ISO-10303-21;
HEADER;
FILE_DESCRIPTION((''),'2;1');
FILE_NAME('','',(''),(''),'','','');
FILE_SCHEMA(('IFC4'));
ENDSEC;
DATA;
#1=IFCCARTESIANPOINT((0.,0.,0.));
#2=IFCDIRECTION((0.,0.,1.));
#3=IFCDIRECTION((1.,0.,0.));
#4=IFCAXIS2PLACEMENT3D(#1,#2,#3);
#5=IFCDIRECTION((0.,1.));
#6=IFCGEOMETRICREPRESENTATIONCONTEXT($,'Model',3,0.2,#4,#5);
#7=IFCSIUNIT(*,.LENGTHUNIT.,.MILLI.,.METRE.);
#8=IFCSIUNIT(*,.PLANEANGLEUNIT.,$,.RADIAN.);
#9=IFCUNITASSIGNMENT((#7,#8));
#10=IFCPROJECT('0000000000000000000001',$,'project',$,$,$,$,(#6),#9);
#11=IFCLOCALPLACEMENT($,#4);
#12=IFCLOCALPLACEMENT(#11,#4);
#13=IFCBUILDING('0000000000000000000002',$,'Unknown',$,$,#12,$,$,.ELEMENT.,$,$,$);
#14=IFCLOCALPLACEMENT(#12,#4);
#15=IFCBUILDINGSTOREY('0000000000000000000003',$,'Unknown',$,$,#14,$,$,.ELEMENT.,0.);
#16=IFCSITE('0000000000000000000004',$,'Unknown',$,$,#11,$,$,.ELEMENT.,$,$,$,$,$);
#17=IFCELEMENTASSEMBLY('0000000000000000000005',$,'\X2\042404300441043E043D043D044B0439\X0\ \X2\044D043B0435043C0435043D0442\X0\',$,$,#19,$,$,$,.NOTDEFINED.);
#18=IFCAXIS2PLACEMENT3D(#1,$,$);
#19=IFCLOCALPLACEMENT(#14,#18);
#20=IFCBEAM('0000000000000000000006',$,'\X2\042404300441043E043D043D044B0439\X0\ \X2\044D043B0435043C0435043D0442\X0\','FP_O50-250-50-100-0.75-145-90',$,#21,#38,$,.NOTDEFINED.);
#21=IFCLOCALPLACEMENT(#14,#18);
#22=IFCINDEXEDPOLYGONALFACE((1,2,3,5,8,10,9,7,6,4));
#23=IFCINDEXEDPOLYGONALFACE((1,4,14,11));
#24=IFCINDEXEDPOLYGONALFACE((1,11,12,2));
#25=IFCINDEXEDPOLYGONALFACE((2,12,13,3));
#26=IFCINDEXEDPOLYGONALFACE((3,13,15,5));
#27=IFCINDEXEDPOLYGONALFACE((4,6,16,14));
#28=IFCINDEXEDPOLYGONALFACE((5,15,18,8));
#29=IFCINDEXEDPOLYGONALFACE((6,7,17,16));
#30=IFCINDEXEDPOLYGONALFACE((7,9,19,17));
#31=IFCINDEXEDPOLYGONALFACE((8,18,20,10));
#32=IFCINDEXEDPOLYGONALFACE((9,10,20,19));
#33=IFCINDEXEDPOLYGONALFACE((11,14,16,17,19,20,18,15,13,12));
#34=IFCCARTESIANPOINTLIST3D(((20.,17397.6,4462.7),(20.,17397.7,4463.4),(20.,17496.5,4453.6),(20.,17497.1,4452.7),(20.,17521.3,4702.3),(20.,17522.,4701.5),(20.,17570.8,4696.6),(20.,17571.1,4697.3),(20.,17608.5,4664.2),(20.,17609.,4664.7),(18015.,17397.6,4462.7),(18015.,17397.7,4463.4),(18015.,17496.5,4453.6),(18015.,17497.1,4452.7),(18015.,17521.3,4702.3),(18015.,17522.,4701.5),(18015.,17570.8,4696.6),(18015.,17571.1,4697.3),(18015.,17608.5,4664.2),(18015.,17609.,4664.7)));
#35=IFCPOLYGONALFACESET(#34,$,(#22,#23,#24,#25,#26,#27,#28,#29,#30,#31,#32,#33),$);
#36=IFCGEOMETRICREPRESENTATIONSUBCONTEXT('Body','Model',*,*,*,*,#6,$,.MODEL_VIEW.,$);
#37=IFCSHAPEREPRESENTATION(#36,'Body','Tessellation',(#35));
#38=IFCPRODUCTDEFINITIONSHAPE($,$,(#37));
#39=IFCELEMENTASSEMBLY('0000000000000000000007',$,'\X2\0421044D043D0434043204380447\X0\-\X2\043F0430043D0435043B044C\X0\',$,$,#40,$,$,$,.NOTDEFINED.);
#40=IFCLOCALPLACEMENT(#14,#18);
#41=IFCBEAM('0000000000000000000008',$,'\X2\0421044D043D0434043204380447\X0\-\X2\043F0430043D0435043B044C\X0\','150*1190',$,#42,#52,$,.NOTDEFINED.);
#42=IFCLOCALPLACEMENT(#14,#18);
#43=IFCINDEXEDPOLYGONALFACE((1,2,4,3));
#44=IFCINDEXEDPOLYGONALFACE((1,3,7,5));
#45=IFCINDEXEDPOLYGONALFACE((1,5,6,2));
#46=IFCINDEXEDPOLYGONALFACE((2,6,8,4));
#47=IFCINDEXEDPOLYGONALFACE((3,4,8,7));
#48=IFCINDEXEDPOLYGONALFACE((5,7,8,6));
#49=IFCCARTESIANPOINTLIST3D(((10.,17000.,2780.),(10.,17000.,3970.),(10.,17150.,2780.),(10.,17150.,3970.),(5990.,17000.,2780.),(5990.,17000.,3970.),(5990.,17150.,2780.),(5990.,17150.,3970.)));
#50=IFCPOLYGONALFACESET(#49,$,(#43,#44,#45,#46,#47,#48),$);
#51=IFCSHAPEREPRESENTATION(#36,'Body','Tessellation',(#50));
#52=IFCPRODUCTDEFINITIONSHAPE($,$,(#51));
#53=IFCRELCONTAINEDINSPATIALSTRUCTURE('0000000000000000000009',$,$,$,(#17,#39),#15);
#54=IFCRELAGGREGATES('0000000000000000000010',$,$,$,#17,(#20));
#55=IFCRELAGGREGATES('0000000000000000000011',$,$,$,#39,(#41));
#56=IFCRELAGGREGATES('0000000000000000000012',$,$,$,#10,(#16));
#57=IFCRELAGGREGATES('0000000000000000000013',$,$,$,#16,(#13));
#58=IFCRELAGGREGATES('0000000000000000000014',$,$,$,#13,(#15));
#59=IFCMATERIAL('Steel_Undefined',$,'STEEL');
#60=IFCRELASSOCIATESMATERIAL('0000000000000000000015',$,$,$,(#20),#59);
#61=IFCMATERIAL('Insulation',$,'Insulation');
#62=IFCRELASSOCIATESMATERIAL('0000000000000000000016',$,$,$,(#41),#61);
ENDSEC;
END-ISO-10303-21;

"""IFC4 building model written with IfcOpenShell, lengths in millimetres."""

from ifc_helpers import new_model, si_unit, direction, frame, origin_with_axes, place, context, subcontext, project, spatial, line, indexed_curve, outline, extrude, material, element, aggregate, save


model = new_model("IFC4")

# Units and contexts
model_context = context("Model", 3, precision=0.2, world=origin_with_axes(), true_north=direction((0.0, 1.0)))
body_context = subcontext(model_context, "Body", "Model", "MODEL_VIEW")
ifc_project = project(units=[si_unit("LENGTHUNIT", "METRE", prefix="MILLI"), si_unit("PLANEANGLEUNIT", "RADIAN")], contexts=[model_context])

# Site, building, storey
site_placement = place(None, origin_with_axes())
site = spatial("IfcSite", under=ifc_project, at=site_placement, Name="Unknown", CompositionType="ELEMENT")
building_placement = place(site_placement, origin_with_axes())
building = spatial("IfcBuilding", under=site, at=building_placement, Name="Unknown", CompositionType="ELEMENT")
storey_placement = place(building_placement, origin_with_axes())
storey = spatial("IfcBuildingStorey", under=building, at=storey_placement, Name="Unknown", CompositionType="ELEMENT", Elevation=0.0)

# Element assemblies, beams
assembly_1_placement = place(storey_placement, frame((20.0, 17533.8, 4575.4), z_axis=(0.0, 0.099504, 0.995037), x_axis=(1.0, 0.0, 0.0)))
assembly_1 = element("IfcElementAssembly", 1, at=assembly_1_placement, inside=storey, Name="Фасонный элемент", PredefinedType="NOTDEFINED")
ifc_material_1 = material(Name="Steel_Undefined", Category="STEEL")
beam_1_placement = place(assembly_1_placement, origin_with_axes())
beam_1 = element("IfcBeam", 2, at=beam_1_placement, material=ifc_material_1, Name="Фасонный элемент", Description="FP_O50-250-50-100-0.75-145-90", PredefinedType="NOTDEFINED", context=body_context, shape_type="SolidModel", body=[
    extrude(outline(indexed_curve([(-125.8, -24.2), (-125.8, -124.2), (-125.0, -124.2), (-125.0, -25.0), (125.0, -25.0), (125.0, 25.0), (96.3, 66.0), (95.7, 65.5), (124.2, 24.8), (124.2, -24.2)], segments=[line(1, 2, 3, 4, 5, 6, 7, 8, 9, 10, 1)])), frame((0.0, 0.0, 0.0), z_axis=(-1.0, 0.0, 0.0), x_axis=(0.0, 0.0, 1.0)), (0.0, 0.0, -1.0), 17995.0),
])
aggregate(assembly_1, [beam_1])
assembly_2_placement = place(storey_placement, frame((10.0, 17075.0, 3375.0), z_axis=(0.0, 0.0, -1.0), x_axis=(1.0, 0.0, 0.0)))
assembly_2 = element("IfcElementAssembly", 3, at=assembly_2_placement, inside=storey, Name="Сэндвич-панель", PredefinedType="NOTDEFINED")
ifc_material_2 = material(Name="Insulation", Category="Insulation")
beam_2_placement = place(assembly_2_placement, origin_with_axes())
beam_2 = element("IfcBeam", 4, at=beam_2_placement, material=ifc_material_2, Name="Сэндвич-панель", Description="150*1190", PredefinedType="NOTDEFINED", context=body_context, shape_type="SolidModel", body=[
    extrude(outline(indexed_curve([(-595.0, -75.0), (595.0, -75.0), (595.0, 75.0), (-595.0, 75.0)], segments=[line(1, 2, 3, 4, 1)])), frame((0.0, 0.0, 0.0), z_axis=(-1.0, 0.0, 0.0), x_axis=(0.0, 0.0, 1.0)), (0.0, 0.0, -1.0), 5980.0),
])
aggregate(assembly_2, [beam_2])

save(model, "model.ifc")
